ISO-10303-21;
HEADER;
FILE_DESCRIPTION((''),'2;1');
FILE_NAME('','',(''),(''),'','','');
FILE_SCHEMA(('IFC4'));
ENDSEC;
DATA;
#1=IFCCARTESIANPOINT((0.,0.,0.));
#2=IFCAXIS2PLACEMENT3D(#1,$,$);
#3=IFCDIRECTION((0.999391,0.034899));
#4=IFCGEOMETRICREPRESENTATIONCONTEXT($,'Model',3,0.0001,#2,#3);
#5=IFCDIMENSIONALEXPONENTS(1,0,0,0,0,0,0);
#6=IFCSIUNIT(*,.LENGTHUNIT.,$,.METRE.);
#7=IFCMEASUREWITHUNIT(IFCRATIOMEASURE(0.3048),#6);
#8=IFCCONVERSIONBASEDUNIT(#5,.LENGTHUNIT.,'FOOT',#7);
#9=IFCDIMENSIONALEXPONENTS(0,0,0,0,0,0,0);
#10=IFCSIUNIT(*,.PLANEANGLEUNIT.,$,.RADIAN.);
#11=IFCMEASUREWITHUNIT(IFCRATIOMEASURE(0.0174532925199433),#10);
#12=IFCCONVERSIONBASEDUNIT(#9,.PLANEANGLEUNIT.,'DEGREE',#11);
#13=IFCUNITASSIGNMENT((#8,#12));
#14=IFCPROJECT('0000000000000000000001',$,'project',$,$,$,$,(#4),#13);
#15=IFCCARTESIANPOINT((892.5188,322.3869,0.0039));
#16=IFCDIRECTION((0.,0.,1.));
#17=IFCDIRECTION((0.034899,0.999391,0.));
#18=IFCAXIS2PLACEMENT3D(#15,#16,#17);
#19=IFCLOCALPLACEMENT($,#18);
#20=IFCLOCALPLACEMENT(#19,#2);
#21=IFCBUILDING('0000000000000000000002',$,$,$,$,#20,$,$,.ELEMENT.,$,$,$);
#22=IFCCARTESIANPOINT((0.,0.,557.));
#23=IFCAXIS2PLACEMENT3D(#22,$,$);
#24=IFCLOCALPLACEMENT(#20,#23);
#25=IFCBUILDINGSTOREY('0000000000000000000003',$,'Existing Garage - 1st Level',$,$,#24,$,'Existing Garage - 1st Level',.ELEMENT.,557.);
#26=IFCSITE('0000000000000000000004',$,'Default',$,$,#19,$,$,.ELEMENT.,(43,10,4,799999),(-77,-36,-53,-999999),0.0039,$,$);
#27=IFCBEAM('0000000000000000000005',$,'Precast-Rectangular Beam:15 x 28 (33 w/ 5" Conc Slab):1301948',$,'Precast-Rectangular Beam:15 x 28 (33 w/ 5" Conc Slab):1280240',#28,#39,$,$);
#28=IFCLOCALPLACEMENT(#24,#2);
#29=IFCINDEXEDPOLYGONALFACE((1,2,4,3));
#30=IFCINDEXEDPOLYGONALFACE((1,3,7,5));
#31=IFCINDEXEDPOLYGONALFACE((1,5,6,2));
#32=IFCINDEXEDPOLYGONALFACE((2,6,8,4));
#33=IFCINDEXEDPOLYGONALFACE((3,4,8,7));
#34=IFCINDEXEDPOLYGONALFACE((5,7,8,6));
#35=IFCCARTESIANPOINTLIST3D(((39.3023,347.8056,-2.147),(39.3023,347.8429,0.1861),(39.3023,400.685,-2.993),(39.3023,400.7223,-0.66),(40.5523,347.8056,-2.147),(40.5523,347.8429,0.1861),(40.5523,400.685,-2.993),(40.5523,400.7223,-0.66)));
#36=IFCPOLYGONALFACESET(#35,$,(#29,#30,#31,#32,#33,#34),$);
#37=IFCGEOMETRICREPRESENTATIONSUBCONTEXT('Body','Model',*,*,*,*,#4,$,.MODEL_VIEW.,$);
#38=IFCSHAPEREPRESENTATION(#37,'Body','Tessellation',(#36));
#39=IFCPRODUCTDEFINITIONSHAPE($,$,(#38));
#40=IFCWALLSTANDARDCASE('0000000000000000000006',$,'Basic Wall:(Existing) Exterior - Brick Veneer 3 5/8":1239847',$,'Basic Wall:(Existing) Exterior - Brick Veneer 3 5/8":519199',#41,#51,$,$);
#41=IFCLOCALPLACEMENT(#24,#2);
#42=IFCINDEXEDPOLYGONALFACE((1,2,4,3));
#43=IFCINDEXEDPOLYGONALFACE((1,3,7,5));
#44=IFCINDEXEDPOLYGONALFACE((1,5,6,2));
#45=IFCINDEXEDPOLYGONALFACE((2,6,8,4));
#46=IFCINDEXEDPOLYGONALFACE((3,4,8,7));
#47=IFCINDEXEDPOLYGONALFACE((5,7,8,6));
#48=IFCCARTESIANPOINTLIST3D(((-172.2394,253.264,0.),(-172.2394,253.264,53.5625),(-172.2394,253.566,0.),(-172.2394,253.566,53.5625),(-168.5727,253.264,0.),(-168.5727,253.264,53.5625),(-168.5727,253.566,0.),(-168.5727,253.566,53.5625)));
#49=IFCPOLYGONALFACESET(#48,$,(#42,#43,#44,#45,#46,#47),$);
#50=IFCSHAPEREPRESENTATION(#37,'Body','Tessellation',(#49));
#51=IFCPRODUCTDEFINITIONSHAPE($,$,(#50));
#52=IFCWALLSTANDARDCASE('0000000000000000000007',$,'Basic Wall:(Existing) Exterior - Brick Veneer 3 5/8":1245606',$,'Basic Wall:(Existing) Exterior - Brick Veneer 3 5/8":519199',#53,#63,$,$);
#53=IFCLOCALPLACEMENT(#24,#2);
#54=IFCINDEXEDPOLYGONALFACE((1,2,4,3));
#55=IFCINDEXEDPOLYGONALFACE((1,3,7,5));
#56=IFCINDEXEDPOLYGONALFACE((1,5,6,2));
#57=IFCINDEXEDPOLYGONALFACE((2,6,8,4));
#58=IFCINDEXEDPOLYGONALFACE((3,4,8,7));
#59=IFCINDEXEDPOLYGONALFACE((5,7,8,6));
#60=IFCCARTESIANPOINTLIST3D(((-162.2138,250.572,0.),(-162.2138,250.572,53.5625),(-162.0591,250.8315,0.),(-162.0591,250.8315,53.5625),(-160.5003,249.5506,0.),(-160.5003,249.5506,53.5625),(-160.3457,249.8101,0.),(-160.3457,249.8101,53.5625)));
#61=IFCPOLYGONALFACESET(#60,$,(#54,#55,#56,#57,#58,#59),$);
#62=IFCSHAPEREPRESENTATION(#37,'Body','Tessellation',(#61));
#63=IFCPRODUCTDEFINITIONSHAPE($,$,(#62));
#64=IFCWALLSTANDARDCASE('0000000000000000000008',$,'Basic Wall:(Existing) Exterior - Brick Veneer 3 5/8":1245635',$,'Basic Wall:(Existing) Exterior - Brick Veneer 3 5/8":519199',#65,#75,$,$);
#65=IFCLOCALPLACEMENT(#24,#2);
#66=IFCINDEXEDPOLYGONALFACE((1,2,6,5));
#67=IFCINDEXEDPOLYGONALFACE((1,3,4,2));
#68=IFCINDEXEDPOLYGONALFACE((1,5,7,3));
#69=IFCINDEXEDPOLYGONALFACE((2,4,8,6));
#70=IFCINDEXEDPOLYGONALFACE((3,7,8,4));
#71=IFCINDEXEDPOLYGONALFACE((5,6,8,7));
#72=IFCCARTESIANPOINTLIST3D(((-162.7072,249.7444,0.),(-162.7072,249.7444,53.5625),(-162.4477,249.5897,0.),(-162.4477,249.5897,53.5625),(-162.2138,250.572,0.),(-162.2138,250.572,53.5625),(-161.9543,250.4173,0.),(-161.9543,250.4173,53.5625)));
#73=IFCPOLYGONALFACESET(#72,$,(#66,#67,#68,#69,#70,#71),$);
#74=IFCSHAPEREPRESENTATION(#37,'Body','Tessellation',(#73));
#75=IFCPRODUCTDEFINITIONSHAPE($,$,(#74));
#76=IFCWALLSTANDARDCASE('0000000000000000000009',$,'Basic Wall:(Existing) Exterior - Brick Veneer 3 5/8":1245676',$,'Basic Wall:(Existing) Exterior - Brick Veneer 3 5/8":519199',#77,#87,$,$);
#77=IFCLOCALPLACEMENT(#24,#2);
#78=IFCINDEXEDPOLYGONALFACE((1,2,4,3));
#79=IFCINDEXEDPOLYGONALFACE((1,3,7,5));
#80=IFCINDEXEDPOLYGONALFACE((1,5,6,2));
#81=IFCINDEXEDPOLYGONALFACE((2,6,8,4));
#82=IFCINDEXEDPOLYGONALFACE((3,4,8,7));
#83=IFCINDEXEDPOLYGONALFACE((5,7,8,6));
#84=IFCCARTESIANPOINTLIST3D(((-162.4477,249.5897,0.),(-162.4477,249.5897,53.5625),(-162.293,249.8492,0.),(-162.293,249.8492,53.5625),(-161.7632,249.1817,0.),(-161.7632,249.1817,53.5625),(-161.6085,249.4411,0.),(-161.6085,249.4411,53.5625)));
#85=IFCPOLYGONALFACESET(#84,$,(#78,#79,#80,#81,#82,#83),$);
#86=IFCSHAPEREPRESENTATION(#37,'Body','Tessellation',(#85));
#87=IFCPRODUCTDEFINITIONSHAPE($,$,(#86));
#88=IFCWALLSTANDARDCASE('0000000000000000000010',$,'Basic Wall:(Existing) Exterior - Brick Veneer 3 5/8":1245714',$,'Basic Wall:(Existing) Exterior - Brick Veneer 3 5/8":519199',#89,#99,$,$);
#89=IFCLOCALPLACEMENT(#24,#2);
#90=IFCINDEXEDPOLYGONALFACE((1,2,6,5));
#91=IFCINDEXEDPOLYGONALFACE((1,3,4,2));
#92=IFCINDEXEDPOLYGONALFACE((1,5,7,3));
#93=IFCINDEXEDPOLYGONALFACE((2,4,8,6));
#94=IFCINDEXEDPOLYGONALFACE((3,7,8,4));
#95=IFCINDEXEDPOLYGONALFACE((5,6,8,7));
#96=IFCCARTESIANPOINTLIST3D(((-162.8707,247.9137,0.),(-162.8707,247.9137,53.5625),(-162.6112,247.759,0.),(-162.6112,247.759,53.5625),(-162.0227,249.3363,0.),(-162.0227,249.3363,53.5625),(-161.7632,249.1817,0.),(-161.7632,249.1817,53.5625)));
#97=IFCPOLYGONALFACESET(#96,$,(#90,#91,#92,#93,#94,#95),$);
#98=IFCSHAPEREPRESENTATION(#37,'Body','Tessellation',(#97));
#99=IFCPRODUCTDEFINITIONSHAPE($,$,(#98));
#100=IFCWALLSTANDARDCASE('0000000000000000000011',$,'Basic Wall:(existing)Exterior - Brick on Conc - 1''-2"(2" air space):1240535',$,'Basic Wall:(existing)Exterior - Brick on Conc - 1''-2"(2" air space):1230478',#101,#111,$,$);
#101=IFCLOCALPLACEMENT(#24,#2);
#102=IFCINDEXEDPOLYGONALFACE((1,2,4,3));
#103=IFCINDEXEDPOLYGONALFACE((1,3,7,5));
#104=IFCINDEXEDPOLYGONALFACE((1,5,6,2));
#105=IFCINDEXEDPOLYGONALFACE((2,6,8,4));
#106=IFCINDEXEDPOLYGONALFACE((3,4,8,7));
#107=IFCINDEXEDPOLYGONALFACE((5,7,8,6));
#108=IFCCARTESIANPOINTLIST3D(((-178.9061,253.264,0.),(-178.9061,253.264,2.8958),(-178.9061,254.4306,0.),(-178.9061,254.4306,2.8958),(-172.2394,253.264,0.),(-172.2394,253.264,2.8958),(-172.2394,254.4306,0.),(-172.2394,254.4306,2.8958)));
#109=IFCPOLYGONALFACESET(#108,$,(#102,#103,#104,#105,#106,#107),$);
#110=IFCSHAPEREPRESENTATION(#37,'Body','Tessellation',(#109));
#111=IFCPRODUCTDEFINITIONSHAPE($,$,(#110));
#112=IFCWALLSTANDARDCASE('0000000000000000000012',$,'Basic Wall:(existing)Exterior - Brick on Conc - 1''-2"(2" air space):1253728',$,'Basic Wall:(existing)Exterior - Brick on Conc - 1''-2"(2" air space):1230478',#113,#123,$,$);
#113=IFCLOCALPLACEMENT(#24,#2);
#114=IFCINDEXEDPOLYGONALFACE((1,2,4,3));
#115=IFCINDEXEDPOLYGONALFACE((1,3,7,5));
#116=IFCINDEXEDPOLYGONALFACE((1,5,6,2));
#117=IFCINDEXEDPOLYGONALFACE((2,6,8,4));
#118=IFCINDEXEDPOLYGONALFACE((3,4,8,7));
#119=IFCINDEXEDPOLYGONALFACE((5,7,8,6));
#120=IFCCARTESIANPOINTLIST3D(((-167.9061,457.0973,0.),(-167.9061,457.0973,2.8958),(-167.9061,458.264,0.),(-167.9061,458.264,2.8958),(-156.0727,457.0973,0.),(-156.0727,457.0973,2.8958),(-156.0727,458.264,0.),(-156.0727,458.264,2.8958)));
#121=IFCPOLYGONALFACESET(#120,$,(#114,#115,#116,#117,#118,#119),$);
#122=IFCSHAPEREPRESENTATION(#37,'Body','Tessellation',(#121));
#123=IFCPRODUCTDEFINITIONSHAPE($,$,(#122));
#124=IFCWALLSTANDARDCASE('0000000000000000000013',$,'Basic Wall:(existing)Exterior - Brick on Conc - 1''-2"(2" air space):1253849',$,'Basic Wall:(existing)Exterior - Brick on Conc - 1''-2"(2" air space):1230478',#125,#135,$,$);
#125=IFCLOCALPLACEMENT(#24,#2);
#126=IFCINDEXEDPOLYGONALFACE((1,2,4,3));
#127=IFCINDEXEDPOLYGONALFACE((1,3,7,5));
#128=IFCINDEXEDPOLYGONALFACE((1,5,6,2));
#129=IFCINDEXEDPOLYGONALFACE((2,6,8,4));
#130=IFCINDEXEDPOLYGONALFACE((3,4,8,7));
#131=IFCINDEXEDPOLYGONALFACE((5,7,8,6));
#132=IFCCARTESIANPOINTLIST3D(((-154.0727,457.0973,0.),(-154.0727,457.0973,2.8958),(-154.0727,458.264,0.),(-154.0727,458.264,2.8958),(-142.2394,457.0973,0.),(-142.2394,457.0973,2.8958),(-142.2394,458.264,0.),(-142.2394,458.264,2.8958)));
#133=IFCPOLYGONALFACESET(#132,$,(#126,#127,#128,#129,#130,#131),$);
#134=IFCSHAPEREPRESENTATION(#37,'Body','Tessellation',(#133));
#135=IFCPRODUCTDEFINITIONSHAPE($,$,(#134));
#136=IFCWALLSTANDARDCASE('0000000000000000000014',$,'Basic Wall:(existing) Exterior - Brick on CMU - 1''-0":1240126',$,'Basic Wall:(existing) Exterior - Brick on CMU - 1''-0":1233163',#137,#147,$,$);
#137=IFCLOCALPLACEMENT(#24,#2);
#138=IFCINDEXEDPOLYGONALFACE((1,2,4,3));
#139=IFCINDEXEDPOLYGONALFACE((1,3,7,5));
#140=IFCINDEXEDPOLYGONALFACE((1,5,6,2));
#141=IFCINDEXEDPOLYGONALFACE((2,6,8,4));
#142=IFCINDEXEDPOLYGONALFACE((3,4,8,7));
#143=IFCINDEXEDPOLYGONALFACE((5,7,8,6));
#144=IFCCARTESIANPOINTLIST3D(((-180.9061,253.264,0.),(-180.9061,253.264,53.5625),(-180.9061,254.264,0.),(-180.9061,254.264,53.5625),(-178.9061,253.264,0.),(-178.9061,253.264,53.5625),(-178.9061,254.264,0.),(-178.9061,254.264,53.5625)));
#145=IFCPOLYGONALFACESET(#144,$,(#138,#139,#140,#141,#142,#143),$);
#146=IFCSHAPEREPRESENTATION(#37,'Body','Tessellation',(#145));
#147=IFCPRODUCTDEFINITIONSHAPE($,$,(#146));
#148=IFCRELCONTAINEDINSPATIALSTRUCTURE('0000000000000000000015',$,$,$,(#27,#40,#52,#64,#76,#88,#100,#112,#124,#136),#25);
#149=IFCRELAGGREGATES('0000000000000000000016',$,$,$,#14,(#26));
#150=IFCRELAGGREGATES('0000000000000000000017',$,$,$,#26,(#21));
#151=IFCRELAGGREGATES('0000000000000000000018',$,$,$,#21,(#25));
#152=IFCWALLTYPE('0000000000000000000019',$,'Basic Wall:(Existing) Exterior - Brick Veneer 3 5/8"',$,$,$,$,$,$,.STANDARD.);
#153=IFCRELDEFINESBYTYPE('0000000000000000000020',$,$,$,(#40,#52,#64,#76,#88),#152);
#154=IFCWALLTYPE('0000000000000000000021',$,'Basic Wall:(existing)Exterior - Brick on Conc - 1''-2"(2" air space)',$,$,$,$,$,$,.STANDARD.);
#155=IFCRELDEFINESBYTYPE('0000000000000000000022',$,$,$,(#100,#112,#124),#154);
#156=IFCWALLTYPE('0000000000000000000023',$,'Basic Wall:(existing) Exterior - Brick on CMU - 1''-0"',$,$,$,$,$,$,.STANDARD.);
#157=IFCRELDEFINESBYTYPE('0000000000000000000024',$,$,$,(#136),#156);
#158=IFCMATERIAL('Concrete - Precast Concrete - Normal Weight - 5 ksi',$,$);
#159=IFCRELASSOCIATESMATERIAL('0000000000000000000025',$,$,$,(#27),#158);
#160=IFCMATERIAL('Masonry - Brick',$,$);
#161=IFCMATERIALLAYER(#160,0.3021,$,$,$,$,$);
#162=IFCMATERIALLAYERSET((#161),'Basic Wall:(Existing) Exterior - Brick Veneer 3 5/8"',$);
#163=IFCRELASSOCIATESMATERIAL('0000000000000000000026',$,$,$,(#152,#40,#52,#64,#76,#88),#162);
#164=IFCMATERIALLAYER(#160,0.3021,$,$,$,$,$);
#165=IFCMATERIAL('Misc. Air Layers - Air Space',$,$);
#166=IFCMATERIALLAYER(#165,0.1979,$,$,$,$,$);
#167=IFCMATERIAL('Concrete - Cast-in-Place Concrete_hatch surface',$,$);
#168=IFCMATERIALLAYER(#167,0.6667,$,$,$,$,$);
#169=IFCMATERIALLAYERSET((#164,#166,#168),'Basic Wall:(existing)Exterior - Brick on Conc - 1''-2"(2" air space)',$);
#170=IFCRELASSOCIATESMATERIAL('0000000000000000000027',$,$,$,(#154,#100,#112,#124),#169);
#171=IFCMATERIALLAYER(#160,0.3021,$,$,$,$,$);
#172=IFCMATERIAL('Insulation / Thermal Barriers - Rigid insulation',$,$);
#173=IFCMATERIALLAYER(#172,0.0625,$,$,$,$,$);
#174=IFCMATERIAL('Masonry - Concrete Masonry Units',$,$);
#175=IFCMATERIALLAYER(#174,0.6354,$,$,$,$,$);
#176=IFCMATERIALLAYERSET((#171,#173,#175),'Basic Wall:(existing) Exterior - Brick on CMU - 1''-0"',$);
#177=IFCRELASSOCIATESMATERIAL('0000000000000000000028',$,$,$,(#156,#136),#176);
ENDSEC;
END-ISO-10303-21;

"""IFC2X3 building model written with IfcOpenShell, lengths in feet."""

from ifc_helpers import new_model, entity, si_unit, converted_unit, direction, frame, frame_2d, origin, place, context, subcontext, project, spatial, rectangle, extrude, material, layer, layer_set, layer_usage, type_object, element, save


model = new_model("IFC2X3")

# Units and contexts
model_context = context("Model", 3, precision=0.0001, world=origin(), true_north=direction((0.999391, 0.034899)))
body_context = subcontext(model_context, "Body", "Model", "MODEL_VIEW")
ifc_project = project(units=[converted_unit("LENGTHUNIT", "FOOT", entity("IfcRatioMeasure", 0.3048), si_unit("LENGTHUNIT", "METRE"), dimensions=[1, 0, 0, 0, 0, 0, 0]), converted_unit("PLANEANGLEUNIT", "DEGREE", entity("IfcRatioMeasure", 0.0174532925199433), si_unit("PLANEANGLEUNIT", "RADIAN"), dimensions=[0, 0, 0, 0, 0, 0, 0])], contexts=[model_context])

# Site, building, storey
site_placement = place(None, frame((892.5188, 322.3869, 0.0039), z_axis=(0.0, 0.0, 1.0), x_axis=(0.034899, 0.999391, 0.0)))
site = spatial("IfcSite", under=ifc_project, at=site_placement, Name="Default", CompositionType="ELEMENT", RefLatitude=(43, 10, 4, 799999), RefLongitude=(-77, -36, -53, -999999), RefElevation=0.0039)
building_placement = place(site_placement, origin())
building = spatial("IfcBuilding", under=site, at=building_placement, CompositionType="ELEMENT")
storey_placement = place(building_placement, frame((0.0, 0.0, 557.0)))
storey = spatial("IfcBuildingStorey", under=building, at=storey_placement, Name="Existing Garage - 1st Level", LongName="Existing Garage - 1st Level", CompositionType="ELEMENT", Elevation=557.0)

# Beam
ifc_material_1 = material(Name="Concrete - Precast Concrete - Normal Weight - 5 ksi")
beam_1_placement = place(storey_placement, frame((39.9273, 346.764, 0.2033), z_axis=(0.0, 0.015998, 0.999872), x_axis=(0.0, 0.999872, -0.015998)))
element("IfcBeam", 1, at=beam_1_placement, inside=storey, material=ifc_material_1, Name="Precast-Rectangular Beam:15 x 28 (33 w/ 5\" Conc Slab):1301948", ObjectType="Precast-Rectangular Beam:15 x 28 (33 w/ 5\" Conc Slab):1280240", context=body_context, shape_type="SweptSolid", body=[
    extrude(rectangle(XDim=2.3333, YDim=1.25, at=frame_2d((0.0, 0.0), x_axis=(1.0, 0.0))), frame((1.0791, 0.0, -1.1667), z_axis=(1.0, 0.0, 0.0), x_axis=(0.0, 0.0, -1.0)), (0.0, 0.0, 1.0), 52.8861),
])

# Walls
ifc_material_2 = material(Name="Masonry - Brick")
ifc_layer_1 = layer(ifc_material_2, 0.3021)
ifc_layer_set_1 = layer_set([ifc_layer_1], Name="Basic Wall:(Existing) Exterior - Brick Veneer 3 5/8\"")
ifc_layer_usage_1 = layer_usage(ifc_layer_set_1, "AXIS2", "POSITIVE", -0.151)
wall_type_1 = type_object("IfcWallType", Name="Basic Wall:(Existing) Exterior - Brick Veneer 3 5/8\"", PredefinedType="STANDARD", material=ifc_layer_set_1)
wall_1_placement = place(storey_placement, frame((-172.2394, 253.415, 0.0)))
element("IfcWallStandardCase", 2, at=wall_1_placement, inside=storey, type_object=wall_type_1, material=ifc_layer_usage_1, Name="Basic Wall:(Existing) Exterior - Brick Veneer 3 5/8\":1239847", ObjectType="Basic Wall:(Existing) Exterior - Brick Veneer 3 5/8\":519199", context=body_context, shape_type="SweptSolid", body=[
    extrude(rectangle(XDim=3.6667, YDim=0.3021, at=frame_2d((1.8333, 0.0), x_axis=(-1.0, 0.0))), origin(), (0.0, 0.0, 1.0), 53.5625),
])
ifc_layer_usage_2 = layer_usage(ifc_layer_set_1, "AXIS2", "POSITIVE", -0.151)
wall_2_placement = place(storey_placement, frame((-160.423, 249.6804, 0.0), z_axis=(0.0, 0.0, 1.0), x_axis=(-0.858972, 0.512022, 0.0)))
element("IfcWallStandardCase", 3, at=wall_2_placement, inside=storey, type_object=wall_type_1, material=ifc_layer_usage_2, Name="Basic Wall:(Existing) Exterior - Brick Veneer 3 5/8\":1245606", ObjectType="Basic Wall:(Existing) Exterior - Brick Veneer 3 5/8\":519199", context=body_context, shape_type="SweptSolid", body=[
    extrude(rectangle(XDim=1.9948, YDim=0.3021, at=frame_2d((0.9974, 0.0), x_axis=(-1.0, 0.0))), origin(), (0.0, 0.0, 1.0), 53.5625),
])
ifc_layer_usage_3 = layer_usage(ifc_layer_set_1, "AXIS2", "POSITIVE", -0.151)
wall_3_placement = place(storey_placement, frame((-162.0841, 250.4947, 0.0), z_axis=(0.0, 0.0, 1.0), x_axis=(-0.512022, -0.858972, 0.0)))
element("IfcWallStandardCase", 4, at=wall_3_placement, inside=storey, type_object=wall_type_1, material=ifc_layer_usage_3, Name="Basic Wall:(Existing) Exterior - Brick Veneer 3 5/8\":1245635", ObjectType="Basic Wall:(Existing) Exterior - Brick Veneer 3 5/8\":519199", context=body_context, shape_type="SweptSolid", body=[
    extrude(rectangle(XDim=0.9635, YDim=0.3021, at=frame_2d((0.4818, 0.0), x_axis=(-1.0, 0.0))), origin(), (0.0, 0.0, 1.0), 53.5625),
])
ifc_layer_usage_4 = layer_usage(ifc_layer_set_1, "AXIS2", "POSITIVE", -0.151)
wall_4_placement = place(storey_placement, frame((-162.3703, 249.7194, 0.0), z_axis=(0.0, 0.0, 1.0), x_axis=(0.858972, -0.512022, 0.0)))
element("IfcWallStandardCase", 5, at=wall_4_placement, inside=storey, type_object=wall_type_1, material=ifc_layer_usage_4, Name="Basic Wall:(Existing) Exterior - Brick Veneer 3 5/8\":1245676", ObjectType="Basic Wall:(Existing) Exterior - Brick Veneer 3 5/8\":519199", context=body_context, shape_type="SweptSolid", body=[
    extrude(rectangle(XDim=0.7969, YDim=0.3021, at=frame_2d((0.3984, 0.0), x_axis=(-1.0, 0.0))), origin(), (0.0, 0.0, 1.0), 53.5625),
])
ifc_layer_usage_5 = layer_usage(ifc_layer_set_1, "AXIS2", "POSITIVE", -0.151)
wall_5_placement = place(storey_placement, frame((-161.8929, 249.259, 0.0), z_axis=(0.0, 0.0, 1.0), x_axis=(-0.512022, -0.858972, 0.0)))
element("IfcWallStandardCase", 6, at=wall_5_placement, inside=storey, type_object=wall_type_1, material=ifc_layer_usage_5, Name="Basic Wall:(Existing) Exterior - Brick Veneer 3 5/8\":1245714", ObjectType="Basic Wall:(Existing) Exterior - Brick Veneer 3 5/8\":519199", context=body_context, shape_type="SweptSolid", body=[
    extrude(rectangle(XDim=1.6563, YDim=0.3021, at=frame_2d((0.8281, 0.0), x_axis=(-1.0, 0.0))), origin(), (0.0, 0.0, 1.0), 53.5625),
])
ifc_layer_2 = layer(ifc_material_2, 0.3021)
ifc_material_3 = material(Name="Misc. Air Layers - Air Space")
ifc_layer_3 = layer(ifc_material_3, 0.1979)
ifc_material_4 = material(Name="Concrete - Cast-in-Place Concrete_hatch surface")
ifc_layer_4 = layer(ifc_material_4, 0.6667)
ifc_layer_set_2 = layer_set([ifc_layer_2, ifc_layer_3, ifc_layer_4], Name="Basic Wall:(existing)Exterior - Brick on Conc - 1'-2\"(2\" air space)")
ifc_layer_usage_6 = layer_usage(ifc_layer_set_2, "AXIS2", "POSITIVE", -0.5833)
wall_type_2 = type_object("IfcWallType", Name="Basic Wall:(existing)Exterior - Brick on Conc - 1'-2\"(2\" air space)", PredefinedType="STANDARD", material=ifc_layer_set_2)
wall_6_placement = place(storey_placement, frame((-178.9061, 253.8473, 0.0)))
element("IfcWallStandardCase", 7, at=wall_6_placement, inside=storey, type_object=wall_type_2, material=ifc_layer_usage_6, Name="Basic Wall:(existing)Exterior - Brick on Conc - 1'-2\"(2\" air space):1240535", ObjectType="Basic Wall:(existing)Exterior - Brick on Conc - 1'-2\"(2\" air space):1230478", context=body_context, shape_type="SweptSolid", body=[
    extrude(rectangle(XDim=6.6667, YDim=1.1667, at=frame_2d((3.3333, 0.0), x_axis=(-1.0, 0.0))), origin(), (0.0, 0.0, 1.0), 2.8958),
])
ifc_layer_usage_7 = layer_usage(ifc_layer_set_2, "AXIS2", "POSITIVE", -0.5833)
wall_7_placement = place(storey_placement, frame((-156.0727, 457.6806, 0.0), z_axis=(0.0, 0.0, 1.0), x_axis=(-1.0, 0.0, 0.0)))
element("IfcWallStandardCase", 8, at=wall_7_placement, inside=storey, type_object=wall_type_2, material=ifc_layer_usage_7, Name="Basic Wall:(existing)Exterior - Brick on Conc - 1'-2\"(2\" air space):1253728", ObjectType="Basic Wall:(existing)Exterior - Brick on Conc - 1'-2\"(2\" air space):1230478", context=body_context, shape_type="SweptSolid", body=[
    extrude(rectangle(XDim=11.8333, YDim=1.1667, at=frame_2d((5.9167, 0.0), x_axis=(-1.0, 0.0))), origin(), (0.0, 0.0, 1.0), 2.8958),
])
ifc_layer_usage_8 = layer_usage(ifc_layer_set_2, "AXIS2", "NEGATIVE", 0.5833)
wall_8_placement = place(storey_placement, frame((-154.0727, 457.6806, 0.0)))
element("IfcWallStandardCase", 9, at=wall_8_placement, inside=storey, type_object=wall_type_2, material=ifc_layer_usage_8, Name="Basic Wall:(existing)Exterior - Brick on Conc - 1'-2\"(2\" air space):1253849", ObjectType="Basic Wall:(existing)Exterior - Brick on Conc - 1'-2\"(2\" air space):1230478", context=body_context, shape_type="SweptSolid", body=[
    extrude(rectangle(XDim=11.8333, YDim=1.1667, at=frame_2d((5.9167, 0.0), x_axis=(-1.0, 0.0))), origin(), (0.0, 0.0, 1.0), 2.8958),
])
ifc_layer_5 = layer(ifc_material_2, 0.3021)
ifc_material_5 = material(Name="Insulation / Thermal Barriers - Rigid insulation")
ifc_layer_6 = layer(ifc_material_5, 0.0625)
ifc_material_6 = material(Name="Masonry - Concrete Masonry Units")
ifc_layer_7 = layer(ifc_material_6, 0.6354)
ifc_layer_set_3 = layer_set([ifc_layer_5, ifc_layer_6, ifc_layer_7], Name="Basic Wall:(existing) Exterior - Brick on CMU - 1'-0\"")
ifc_layer_usage_9 = layer_usage(ifc_layer_set_3, "AXIS2", "POSITIVE", -0.5)
wall_type_3 = type_object("IfcWallType", Name="Basic Wall:(existing) Exterior - Brick on CMU - 1'-0\"", PredefinedType="STANDARD", material=ifc_layer_set_3)
wall_9_placement = place(storey_placement, frame((-180.9061, 253.764, 0.0)))
element("IfcWallStandardCase", 10, at=wall_9_placement, inside=storey, type_object=wall_type_3, material=ifc_layer_usage_9, Name="Basic Wall:(existing) Exterior - Brick on CMU - 1'-0\":1240126", ObjectType="Basic Wall:(existing) Exterior - Brick on CMU - 1'-0\":1233163", context=body_context, shape_type="SweptSolid", body=[
    extrude(rectangle(XDim=2.0, YDim=1.0, at=frame_2d((1.0, 0.0), x_axis=(-1.0, 0.0))), origin(), (0.0, 0.0, 1.0), 53.5625),
])

save(model, "model.ifc")
